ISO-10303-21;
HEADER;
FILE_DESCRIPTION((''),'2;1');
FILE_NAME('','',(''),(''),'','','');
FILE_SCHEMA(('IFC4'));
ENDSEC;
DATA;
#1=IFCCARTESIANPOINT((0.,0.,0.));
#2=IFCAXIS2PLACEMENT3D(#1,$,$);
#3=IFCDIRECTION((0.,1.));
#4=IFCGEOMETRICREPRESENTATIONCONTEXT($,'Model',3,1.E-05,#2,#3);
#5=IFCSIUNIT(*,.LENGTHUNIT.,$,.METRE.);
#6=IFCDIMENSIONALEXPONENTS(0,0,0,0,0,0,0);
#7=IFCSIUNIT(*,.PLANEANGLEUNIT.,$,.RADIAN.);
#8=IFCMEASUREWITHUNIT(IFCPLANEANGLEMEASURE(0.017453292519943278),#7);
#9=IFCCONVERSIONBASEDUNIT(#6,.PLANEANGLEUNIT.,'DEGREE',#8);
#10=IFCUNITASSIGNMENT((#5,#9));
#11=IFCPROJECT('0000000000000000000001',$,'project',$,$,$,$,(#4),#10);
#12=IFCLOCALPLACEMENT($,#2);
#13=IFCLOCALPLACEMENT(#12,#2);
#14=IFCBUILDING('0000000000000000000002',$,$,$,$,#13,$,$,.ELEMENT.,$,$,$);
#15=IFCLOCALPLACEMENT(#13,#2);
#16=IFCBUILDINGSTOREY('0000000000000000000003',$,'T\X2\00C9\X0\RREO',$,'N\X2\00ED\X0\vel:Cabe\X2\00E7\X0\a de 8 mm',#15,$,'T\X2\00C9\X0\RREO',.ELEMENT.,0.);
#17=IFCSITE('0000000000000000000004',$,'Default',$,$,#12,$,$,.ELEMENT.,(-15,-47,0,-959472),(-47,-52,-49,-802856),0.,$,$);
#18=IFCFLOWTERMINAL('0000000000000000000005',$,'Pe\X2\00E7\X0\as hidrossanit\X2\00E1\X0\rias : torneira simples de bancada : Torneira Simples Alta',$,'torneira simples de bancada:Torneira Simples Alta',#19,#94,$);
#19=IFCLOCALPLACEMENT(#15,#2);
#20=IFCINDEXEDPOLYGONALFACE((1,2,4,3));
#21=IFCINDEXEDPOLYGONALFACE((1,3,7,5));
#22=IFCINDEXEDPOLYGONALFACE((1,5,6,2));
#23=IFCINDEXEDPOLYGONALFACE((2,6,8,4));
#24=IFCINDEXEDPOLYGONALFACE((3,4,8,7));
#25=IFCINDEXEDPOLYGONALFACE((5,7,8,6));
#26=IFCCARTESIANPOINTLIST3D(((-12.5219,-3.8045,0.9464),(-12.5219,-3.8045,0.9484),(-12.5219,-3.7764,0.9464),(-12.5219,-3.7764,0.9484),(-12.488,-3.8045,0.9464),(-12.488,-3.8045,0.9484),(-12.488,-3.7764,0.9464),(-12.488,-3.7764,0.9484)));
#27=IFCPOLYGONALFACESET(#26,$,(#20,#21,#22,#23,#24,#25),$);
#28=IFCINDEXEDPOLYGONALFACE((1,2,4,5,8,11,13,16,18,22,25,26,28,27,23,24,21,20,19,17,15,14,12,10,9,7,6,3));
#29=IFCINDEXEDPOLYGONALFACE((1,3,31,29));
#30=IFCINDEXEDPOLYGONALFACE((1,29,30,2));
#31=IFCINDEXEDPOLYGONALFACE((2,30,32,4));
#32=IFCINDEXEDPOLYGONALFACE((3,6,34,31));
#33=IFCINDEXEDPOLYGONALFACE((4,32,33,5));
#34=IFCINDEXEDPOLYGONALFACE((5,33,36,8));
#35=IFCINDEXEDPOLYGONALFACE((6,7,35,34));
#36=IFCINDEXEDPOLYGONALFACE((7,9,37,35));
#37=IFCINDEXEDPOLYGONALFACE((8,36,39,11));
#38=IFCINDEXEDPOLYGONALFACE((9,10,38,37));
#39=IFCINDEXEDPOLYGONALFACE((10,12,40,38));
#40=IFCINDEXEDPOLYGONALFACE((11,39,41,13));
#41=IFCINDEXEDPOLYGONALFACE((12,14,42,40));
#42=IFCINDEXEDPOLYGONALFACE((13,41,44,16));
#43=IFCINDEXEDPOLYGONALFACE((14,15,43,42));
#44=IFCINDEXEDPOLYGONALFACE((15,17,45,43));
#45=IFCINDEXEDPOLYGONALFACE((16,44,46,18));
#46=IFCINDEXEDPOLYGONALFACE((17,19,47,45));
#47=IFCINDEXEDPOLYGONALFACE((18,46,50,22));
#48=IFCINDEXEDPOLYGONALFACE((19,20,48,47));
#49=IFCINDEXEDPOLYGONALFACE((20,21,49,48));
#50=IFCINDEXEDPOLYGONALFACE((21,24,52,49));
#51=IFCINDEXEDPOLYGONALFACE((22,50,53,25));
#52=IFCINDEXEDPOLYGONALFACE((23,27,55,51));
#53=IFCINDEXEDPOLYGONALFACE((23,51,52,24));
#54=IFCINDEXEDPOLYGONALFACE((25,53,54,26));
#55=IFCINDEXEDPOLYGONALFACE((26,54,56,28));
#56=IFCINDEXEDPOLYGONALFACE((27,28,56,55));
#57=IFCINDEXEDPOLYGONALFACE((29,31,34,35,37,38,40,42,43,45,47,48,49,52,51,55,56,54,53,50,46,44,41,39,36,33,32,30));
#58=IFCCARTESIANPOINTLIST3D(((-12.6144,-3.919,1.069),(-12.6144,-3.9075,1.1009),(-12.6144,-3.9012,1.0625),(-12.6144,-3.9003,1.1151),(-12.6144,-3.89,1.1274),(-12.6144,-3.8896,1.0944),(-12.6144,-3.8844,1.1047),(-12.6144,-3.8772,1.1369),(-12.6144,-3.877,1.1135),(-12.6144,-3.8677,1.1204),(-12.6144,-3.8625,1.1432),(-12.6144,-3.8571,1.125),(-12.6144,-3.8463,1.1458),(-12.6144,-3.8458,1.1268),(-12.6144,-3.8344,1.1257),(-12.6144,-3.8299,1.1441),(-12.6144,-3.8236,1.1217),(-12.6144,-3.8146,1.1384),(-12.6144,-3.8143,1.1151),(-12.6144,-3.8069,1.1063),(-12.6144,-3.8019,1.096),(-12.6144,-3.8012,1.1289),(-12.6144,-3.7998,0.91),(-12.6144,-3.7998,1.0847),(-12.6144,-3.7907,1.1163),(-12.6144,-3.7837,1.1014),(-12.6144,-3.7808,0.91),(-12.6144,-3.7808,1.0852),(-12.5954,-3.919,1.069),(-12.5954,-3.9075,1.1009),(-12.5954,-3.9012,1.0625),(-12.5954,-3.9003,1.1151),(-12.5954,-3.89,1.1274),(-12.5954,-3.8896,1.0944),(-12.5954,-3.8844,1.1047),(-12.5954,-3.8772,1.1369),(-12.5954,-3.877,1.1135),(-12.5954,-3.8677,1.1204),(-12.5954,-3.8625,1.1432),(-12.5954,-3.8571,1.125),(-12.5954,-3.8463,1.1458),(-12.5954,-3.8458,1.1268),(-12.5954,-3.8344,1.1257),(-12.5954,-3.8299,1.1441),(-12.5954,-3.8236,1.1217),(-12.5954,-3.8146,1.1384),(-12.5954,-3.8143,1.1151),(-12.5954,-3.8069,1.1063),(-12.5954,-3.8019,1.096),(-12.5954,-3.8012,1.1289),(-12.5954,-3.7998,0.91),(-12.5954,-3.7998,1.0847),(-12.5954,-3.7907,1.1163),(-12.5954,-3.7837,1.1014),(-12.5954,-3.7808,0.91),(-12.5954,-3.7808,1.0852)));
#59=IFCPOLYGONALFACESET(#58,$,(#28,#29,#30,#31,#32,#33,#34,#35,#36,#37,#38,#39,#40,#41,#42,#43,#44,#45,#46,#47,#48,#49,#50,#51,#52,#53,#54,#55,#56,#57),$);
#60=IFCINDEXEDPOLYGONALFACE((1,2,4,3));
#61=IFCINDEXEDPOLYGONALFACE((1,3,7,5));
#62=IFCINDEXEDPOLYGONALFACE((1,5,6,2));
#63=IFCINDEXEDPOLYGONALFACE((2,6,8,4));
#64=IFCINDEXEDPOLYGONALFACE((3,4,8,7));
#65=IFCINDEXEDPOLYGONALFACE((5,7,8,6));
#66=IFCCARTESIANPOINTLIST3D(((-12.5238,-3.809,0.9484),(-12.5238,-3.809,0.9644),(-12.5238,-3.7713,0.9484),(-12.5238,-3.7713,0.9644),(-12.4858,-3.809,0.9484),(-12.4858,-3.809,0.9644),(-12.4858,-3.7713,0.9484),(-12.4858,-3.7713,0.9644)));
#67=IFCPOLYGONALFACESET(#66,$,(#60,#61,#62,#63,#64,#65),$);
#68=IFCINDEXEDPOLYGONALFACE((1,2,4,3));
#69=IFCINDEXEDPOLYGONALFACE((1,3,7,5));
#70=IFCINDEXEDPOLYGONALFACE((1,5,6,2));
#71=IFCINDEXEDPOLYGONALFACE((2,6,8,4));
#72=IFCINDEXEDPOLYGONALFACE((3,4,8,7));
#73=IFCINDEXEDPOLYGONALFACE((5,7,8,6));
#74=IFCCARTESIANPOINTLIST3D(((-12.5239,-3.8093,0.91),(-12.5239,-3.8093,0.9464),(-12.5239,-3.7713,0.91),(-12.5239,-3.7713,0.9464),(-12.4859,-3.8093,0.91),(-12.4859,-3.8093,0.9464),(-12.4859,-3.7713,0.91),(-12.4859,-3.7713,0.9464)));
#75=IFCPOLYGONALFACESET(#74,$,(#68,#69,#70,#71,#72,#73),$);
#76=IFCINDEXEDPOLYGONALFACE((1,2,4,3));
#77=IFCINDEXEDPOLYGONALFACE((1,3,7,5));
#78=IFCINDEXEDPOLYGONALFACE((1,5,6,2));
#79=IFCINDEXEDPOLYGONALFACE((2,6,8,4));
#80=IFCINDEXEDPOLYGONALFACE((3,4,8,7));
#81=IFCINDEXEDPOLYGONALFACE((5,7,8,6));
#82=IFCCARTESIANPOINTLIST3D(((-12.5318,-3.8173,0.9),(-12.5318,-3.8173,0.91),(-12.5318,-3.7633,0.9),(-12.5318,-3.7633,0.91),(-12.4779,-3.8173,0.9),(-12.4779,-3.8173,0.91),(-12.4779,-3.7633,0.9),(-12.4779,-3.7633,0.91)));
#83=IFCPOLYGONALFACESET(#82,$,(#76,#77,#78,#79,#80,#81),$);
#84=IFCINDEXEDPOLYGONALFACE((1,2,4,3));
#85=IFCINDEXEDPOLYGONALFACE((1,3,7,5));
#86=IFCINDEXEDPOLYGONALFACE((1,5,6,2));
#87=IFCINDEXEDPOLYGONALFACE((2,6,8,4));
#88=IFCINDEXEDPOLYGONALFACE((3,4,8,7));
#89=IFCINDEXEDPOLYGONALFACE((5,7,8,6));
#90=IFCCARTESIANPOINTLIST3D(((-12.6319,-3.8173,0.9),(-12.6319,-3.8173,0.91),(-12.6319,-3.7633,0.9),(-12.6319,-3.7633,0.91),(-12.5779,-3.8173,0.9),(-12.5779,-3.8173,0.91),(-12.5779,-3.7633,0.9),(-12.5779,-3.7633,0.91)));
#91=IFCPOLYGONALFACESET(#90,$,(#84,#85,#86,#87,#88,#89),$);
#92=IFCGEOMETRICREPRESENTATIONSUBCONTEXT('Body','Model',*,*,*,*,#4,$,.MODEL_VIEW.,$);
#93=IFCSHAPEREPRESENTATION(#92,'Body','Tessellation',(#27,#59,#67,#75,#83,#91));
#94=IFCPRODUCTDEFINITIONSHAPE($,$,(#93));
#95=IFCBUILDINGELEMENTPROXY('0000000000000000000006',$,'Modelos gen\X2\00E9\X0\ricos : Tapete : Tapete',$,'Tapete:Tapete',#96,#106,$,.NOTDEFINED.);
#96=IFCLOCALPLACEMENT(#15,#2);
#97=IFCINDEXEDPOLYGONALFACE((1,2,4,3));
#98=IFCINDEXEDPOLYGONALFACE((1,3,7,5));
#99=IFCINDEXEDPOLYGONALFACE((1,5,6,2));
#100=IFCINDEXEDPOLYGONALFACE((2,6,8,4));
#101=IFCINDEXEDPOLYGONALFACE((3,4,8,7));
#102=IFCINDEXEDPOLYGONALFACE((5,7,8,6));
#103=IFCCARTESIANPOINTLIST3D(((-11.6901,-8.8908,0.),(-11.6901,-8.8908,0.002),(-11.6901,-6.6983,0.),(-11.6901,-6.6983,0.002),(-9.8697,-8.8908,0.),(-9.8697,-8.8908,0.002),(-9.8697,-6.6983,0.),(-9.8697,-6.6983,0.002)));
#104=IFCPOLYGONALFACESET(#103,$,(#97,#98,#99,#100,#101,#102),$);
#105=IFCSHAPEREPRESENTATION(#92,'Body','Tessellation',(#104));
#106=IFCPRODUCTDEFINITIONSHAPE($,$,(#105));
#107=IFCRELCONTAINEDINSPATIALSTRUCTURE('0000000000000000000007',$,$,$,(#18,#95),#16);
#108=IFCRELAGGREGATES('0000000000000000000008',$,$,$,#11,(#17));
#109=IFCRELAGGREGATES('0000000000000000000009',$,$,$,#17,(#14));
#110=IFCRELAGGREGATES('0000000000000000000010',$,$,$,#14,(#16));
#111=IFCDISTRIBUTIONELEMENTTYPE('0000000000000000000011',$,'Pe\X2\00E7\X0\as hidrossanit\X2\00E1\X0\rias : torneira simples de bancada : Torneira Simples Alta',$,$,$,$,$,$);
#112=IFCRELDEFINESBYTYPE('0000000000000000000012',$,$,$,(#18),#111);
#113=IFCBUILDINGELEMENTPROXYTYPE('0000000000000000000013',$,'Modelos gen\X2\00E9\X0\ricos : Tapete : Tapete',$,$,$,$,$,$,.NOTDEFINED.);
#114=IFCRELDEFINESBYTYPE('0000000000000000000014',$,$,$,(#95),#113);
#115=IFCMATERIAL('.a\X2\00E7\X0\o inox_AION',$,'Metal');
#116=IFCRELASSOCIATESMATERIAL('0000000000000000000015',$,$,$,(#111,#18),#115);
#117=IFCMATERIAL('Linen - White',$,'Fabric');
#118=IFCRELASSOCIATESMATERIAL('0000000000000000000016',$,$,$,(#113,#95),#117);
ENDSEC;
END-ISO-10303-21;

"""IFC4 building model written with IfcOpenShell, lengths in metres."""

from ifc_helpers import new_model, entity, si_unit, converted_unit, direction, frame, origin, place, context, subcontext, project, spatial, line, arc, indexed_curve, outline, extrude, source, transform, mapped, material, type_object, type_shapes, element, save


model = new_model("IFC4")

# Units and contexts
model_context = context("Model", 3, precision=1e-05, world=origin(), true_north=direction((0.0, 1.0)))
body_context = subcontext(model_context, "Body", "Model", "MODEL_VIEW")
ifc_project = project(units=[si_unit("LENGTHUNIT", "METRE"), converted_unit("PLANEANGLEUNIT", "DEGREE", entity("IfcPlaneAngleMeasure", 0.017453292519943278), si_unit("PLANEANGLEUNIT", "RADIAN"), dimensions=[0, 0, 0, 0, 0, 0, 0])], contexts=[model_context])

# Site, building, storey
site_placement = place(None, origin())
site = spatial("IfcSite", under=ifc_project, at=site_placement, Name="Default", CompositionType="ELEMENT", RefLatitude=(-15, -47, 0, -959472), RefLongitude=(-47, -52, -49, -802856), RefElevation=0.0)
building_placement = place(site_placement, origin())
building = spatial("IfcBuilding", under=site, at=building_placement, CompositionType="ELEMENT")
storey_placement = place(building_placement, origin())
storey = spatial("IfcBuildingStorey", under=building, at=storey_placement, Name="TÉRREO", ObjectType="Nível:Cabeça de 8 mm", LongName="TÉRREO", CompositionType="ELEMENT", Elevation=0.0)

# Flow terminal
ifc_material_1 = material(Name=".aço inox_AION", Category="Metal")
distribution_element_type_1 = type_object("IfcDistributionElementType", Name="Peças hidrossanitárias : torneira simples de bancada : Torneira Simples Alta", material=ifc_material_1)
shared_shape_1 = source(origin(), body_context, "Body", "SweptSolid", [
    extrude(outline(indexed_curve([(-0.0169, -0.014), (0.0169, -0.014), (0.0169, 0.014), (-0.0169, 0.014), (-0.0169, -0.014)], self_intersect=False)), frame((0.1, -0.0001, 0.0464), z_axis=(0.0, 0.0, 1.0), x_axis=(-1.0, 0.0, 0.0)), (0.0, 0.0, 1.0), 0.002),
    extrude(outline(indexed_curve([(0.0848, -0.0119), (0.0775, 0.019), (0.057, 0.0432), (0.0298, 0.0634), (0.0185, 0.0481), (0.0457, 0.028), (0.0605, 0.0104), (0.0658, -0.0119), (0.0489, -0.0469), (0.011, -0.0554), (-0.1566, -0.0058), (-0.162, -0.024), (0.006, -0.0738), (0.0605, -0.062)], segments=[arc(1, 2, 3), line(3, 4, 5, 6), arc(6, 7, 8), arc(8, 9, 10), line(10, 11, 12, 13), arc(13, 14, 1)], self_intersect=False)), frame((-0.0095, -0.0595, 0.1585), z_axis=(1.0, 0.0, 0.0), x_axis=(0.0, -0.284128, 0.958786)), (0.0, 0.0, 1.0), 0.019),
    extrude(outline(indexed_curve([(-0.019, -0.0189), (0.019, -0.0189), (0.019, 0.0189), (-0.019, 0.0189), (-0.019, -0.0189)], self_intersect=False)), frame((0.1001, 0.0002, 0.0484), z_axis=(0.0, 0.0, 1.0), x_axis=(-1.0, 0.0, 0.0)), (0.0, 0.0, 1.0), 0.016),
    extrude(outline(indexed_curve([(-0.019, -0.019), (0.019, -0.019), (0.019, 0.019), (-0.019, 0.019), (-0.019, -0.019)], self_intersect=False)), frame((0.1001, 0.0, 0.01), z_axis=(0.0, 0.0, 1.0), x_axis=(-1.0, 0.0, 0.0)), (0.0, 0.0, 1.0), 0.0364),
    extrude(outline(indexed_curve([(-0.027, -0.027), (0.027, -0.027), (0.027, 0.027), (-0.027, 0.027), (-0.027, -0.027)], self_intersect=False)), frame((0.1001, 0.0, 0.0), z_axis=(0.0, 0.0, 1.0), x_axis=(-1.0, 0.0, 0.0)), (0.0, 0.0, 1.0), 0.01),
    extrude(outline(indexed_curve([(-0.027, -0.027), (0.027, -0.027), (0.027, 0.027), (-0.027, 0.027), (-0.027, -0.027)], self_intersect=False)), frame((0.0, 0.0, 0.0), z_axis=(0.0, 0.0, 1.0), x_axis=(-1.0, 0.0, 0.0)), (0.0, 0.0, 1.0), 0.01),
])
type_shapes(distribution_element_type_1, [shared_shape_1])
flow_terminal_1_placement = place(storey_placement, frame((-12.6049, -3.7903, 0.9)))
element("IfcFlowTerminal", 1, at=flow_terminal_1_placement, inside=storey, type_object=distribution_element_type_1, material=ifc_material_1, Name="Peças hidrossanitárias : torneira simples de bancada : Torneira Simples Alta", ObjectType="torneira simples de bancada:Torneira Simples Alta", context=body_context, shape_type="MappedRepresentation", body=[
    mapped(shared_shape_1, transform((0.0, 0.0, 0.0), scale=1.0)),
])

# Building element proxy
ifc_material_2 = material(Name="Linen - White", Category="Fabric")
building_element_proxy_type = type_object("IfcBuildingElementProxyType", Name="Modelos genéricos : Tapete : Tapete", PredefinedType="NOTDEFINED", material=ifc_material_2)
shared_shape_2 = source(origin(), body_context, "Body", "SweptSolid", [
    extrude(outline(indexed_curve([(-1.0962, -0.9102), (1.0962, -0.9102), (1.0962, 0.9102), (-1.0962, 0.9102), (-1.0962, -0.9102)], self_intersect=False)), frame((0.0, 0.0, 0.0), z_axis=(0.0, 0.0, 1.0), x_axis=(-1.0, 0.0, 0.0)), (0.0, 0.0, 1.0), 0.002),
])
type_shapes(building_element_proxy_type, [shared_shape_2])
proxy_placement = place(storey_placement, frame((-10.7799, -7.7945, 0.0), z_axis=(0.0, 0.0, 1.0), x_axis=(0.0, 1.0, 0.0)))
element("IfcBuildingElementProxy", 2, at=proxy_placement, inside=storey, type_object=building_element_proxy_type, material=ifc_material_2, Name="Modelos genéricos : Tapete : Tapete", ObjectType="Tapete:Tapete", PredefinedType="NOTDEFINED", context=body_context, shape_type="MappedRepresentation", body=[
    mapped(shared_shape_2, transform((0.0, 0.0, 0.0), scale=1.0)),
])

save(model, "model.ifc")
